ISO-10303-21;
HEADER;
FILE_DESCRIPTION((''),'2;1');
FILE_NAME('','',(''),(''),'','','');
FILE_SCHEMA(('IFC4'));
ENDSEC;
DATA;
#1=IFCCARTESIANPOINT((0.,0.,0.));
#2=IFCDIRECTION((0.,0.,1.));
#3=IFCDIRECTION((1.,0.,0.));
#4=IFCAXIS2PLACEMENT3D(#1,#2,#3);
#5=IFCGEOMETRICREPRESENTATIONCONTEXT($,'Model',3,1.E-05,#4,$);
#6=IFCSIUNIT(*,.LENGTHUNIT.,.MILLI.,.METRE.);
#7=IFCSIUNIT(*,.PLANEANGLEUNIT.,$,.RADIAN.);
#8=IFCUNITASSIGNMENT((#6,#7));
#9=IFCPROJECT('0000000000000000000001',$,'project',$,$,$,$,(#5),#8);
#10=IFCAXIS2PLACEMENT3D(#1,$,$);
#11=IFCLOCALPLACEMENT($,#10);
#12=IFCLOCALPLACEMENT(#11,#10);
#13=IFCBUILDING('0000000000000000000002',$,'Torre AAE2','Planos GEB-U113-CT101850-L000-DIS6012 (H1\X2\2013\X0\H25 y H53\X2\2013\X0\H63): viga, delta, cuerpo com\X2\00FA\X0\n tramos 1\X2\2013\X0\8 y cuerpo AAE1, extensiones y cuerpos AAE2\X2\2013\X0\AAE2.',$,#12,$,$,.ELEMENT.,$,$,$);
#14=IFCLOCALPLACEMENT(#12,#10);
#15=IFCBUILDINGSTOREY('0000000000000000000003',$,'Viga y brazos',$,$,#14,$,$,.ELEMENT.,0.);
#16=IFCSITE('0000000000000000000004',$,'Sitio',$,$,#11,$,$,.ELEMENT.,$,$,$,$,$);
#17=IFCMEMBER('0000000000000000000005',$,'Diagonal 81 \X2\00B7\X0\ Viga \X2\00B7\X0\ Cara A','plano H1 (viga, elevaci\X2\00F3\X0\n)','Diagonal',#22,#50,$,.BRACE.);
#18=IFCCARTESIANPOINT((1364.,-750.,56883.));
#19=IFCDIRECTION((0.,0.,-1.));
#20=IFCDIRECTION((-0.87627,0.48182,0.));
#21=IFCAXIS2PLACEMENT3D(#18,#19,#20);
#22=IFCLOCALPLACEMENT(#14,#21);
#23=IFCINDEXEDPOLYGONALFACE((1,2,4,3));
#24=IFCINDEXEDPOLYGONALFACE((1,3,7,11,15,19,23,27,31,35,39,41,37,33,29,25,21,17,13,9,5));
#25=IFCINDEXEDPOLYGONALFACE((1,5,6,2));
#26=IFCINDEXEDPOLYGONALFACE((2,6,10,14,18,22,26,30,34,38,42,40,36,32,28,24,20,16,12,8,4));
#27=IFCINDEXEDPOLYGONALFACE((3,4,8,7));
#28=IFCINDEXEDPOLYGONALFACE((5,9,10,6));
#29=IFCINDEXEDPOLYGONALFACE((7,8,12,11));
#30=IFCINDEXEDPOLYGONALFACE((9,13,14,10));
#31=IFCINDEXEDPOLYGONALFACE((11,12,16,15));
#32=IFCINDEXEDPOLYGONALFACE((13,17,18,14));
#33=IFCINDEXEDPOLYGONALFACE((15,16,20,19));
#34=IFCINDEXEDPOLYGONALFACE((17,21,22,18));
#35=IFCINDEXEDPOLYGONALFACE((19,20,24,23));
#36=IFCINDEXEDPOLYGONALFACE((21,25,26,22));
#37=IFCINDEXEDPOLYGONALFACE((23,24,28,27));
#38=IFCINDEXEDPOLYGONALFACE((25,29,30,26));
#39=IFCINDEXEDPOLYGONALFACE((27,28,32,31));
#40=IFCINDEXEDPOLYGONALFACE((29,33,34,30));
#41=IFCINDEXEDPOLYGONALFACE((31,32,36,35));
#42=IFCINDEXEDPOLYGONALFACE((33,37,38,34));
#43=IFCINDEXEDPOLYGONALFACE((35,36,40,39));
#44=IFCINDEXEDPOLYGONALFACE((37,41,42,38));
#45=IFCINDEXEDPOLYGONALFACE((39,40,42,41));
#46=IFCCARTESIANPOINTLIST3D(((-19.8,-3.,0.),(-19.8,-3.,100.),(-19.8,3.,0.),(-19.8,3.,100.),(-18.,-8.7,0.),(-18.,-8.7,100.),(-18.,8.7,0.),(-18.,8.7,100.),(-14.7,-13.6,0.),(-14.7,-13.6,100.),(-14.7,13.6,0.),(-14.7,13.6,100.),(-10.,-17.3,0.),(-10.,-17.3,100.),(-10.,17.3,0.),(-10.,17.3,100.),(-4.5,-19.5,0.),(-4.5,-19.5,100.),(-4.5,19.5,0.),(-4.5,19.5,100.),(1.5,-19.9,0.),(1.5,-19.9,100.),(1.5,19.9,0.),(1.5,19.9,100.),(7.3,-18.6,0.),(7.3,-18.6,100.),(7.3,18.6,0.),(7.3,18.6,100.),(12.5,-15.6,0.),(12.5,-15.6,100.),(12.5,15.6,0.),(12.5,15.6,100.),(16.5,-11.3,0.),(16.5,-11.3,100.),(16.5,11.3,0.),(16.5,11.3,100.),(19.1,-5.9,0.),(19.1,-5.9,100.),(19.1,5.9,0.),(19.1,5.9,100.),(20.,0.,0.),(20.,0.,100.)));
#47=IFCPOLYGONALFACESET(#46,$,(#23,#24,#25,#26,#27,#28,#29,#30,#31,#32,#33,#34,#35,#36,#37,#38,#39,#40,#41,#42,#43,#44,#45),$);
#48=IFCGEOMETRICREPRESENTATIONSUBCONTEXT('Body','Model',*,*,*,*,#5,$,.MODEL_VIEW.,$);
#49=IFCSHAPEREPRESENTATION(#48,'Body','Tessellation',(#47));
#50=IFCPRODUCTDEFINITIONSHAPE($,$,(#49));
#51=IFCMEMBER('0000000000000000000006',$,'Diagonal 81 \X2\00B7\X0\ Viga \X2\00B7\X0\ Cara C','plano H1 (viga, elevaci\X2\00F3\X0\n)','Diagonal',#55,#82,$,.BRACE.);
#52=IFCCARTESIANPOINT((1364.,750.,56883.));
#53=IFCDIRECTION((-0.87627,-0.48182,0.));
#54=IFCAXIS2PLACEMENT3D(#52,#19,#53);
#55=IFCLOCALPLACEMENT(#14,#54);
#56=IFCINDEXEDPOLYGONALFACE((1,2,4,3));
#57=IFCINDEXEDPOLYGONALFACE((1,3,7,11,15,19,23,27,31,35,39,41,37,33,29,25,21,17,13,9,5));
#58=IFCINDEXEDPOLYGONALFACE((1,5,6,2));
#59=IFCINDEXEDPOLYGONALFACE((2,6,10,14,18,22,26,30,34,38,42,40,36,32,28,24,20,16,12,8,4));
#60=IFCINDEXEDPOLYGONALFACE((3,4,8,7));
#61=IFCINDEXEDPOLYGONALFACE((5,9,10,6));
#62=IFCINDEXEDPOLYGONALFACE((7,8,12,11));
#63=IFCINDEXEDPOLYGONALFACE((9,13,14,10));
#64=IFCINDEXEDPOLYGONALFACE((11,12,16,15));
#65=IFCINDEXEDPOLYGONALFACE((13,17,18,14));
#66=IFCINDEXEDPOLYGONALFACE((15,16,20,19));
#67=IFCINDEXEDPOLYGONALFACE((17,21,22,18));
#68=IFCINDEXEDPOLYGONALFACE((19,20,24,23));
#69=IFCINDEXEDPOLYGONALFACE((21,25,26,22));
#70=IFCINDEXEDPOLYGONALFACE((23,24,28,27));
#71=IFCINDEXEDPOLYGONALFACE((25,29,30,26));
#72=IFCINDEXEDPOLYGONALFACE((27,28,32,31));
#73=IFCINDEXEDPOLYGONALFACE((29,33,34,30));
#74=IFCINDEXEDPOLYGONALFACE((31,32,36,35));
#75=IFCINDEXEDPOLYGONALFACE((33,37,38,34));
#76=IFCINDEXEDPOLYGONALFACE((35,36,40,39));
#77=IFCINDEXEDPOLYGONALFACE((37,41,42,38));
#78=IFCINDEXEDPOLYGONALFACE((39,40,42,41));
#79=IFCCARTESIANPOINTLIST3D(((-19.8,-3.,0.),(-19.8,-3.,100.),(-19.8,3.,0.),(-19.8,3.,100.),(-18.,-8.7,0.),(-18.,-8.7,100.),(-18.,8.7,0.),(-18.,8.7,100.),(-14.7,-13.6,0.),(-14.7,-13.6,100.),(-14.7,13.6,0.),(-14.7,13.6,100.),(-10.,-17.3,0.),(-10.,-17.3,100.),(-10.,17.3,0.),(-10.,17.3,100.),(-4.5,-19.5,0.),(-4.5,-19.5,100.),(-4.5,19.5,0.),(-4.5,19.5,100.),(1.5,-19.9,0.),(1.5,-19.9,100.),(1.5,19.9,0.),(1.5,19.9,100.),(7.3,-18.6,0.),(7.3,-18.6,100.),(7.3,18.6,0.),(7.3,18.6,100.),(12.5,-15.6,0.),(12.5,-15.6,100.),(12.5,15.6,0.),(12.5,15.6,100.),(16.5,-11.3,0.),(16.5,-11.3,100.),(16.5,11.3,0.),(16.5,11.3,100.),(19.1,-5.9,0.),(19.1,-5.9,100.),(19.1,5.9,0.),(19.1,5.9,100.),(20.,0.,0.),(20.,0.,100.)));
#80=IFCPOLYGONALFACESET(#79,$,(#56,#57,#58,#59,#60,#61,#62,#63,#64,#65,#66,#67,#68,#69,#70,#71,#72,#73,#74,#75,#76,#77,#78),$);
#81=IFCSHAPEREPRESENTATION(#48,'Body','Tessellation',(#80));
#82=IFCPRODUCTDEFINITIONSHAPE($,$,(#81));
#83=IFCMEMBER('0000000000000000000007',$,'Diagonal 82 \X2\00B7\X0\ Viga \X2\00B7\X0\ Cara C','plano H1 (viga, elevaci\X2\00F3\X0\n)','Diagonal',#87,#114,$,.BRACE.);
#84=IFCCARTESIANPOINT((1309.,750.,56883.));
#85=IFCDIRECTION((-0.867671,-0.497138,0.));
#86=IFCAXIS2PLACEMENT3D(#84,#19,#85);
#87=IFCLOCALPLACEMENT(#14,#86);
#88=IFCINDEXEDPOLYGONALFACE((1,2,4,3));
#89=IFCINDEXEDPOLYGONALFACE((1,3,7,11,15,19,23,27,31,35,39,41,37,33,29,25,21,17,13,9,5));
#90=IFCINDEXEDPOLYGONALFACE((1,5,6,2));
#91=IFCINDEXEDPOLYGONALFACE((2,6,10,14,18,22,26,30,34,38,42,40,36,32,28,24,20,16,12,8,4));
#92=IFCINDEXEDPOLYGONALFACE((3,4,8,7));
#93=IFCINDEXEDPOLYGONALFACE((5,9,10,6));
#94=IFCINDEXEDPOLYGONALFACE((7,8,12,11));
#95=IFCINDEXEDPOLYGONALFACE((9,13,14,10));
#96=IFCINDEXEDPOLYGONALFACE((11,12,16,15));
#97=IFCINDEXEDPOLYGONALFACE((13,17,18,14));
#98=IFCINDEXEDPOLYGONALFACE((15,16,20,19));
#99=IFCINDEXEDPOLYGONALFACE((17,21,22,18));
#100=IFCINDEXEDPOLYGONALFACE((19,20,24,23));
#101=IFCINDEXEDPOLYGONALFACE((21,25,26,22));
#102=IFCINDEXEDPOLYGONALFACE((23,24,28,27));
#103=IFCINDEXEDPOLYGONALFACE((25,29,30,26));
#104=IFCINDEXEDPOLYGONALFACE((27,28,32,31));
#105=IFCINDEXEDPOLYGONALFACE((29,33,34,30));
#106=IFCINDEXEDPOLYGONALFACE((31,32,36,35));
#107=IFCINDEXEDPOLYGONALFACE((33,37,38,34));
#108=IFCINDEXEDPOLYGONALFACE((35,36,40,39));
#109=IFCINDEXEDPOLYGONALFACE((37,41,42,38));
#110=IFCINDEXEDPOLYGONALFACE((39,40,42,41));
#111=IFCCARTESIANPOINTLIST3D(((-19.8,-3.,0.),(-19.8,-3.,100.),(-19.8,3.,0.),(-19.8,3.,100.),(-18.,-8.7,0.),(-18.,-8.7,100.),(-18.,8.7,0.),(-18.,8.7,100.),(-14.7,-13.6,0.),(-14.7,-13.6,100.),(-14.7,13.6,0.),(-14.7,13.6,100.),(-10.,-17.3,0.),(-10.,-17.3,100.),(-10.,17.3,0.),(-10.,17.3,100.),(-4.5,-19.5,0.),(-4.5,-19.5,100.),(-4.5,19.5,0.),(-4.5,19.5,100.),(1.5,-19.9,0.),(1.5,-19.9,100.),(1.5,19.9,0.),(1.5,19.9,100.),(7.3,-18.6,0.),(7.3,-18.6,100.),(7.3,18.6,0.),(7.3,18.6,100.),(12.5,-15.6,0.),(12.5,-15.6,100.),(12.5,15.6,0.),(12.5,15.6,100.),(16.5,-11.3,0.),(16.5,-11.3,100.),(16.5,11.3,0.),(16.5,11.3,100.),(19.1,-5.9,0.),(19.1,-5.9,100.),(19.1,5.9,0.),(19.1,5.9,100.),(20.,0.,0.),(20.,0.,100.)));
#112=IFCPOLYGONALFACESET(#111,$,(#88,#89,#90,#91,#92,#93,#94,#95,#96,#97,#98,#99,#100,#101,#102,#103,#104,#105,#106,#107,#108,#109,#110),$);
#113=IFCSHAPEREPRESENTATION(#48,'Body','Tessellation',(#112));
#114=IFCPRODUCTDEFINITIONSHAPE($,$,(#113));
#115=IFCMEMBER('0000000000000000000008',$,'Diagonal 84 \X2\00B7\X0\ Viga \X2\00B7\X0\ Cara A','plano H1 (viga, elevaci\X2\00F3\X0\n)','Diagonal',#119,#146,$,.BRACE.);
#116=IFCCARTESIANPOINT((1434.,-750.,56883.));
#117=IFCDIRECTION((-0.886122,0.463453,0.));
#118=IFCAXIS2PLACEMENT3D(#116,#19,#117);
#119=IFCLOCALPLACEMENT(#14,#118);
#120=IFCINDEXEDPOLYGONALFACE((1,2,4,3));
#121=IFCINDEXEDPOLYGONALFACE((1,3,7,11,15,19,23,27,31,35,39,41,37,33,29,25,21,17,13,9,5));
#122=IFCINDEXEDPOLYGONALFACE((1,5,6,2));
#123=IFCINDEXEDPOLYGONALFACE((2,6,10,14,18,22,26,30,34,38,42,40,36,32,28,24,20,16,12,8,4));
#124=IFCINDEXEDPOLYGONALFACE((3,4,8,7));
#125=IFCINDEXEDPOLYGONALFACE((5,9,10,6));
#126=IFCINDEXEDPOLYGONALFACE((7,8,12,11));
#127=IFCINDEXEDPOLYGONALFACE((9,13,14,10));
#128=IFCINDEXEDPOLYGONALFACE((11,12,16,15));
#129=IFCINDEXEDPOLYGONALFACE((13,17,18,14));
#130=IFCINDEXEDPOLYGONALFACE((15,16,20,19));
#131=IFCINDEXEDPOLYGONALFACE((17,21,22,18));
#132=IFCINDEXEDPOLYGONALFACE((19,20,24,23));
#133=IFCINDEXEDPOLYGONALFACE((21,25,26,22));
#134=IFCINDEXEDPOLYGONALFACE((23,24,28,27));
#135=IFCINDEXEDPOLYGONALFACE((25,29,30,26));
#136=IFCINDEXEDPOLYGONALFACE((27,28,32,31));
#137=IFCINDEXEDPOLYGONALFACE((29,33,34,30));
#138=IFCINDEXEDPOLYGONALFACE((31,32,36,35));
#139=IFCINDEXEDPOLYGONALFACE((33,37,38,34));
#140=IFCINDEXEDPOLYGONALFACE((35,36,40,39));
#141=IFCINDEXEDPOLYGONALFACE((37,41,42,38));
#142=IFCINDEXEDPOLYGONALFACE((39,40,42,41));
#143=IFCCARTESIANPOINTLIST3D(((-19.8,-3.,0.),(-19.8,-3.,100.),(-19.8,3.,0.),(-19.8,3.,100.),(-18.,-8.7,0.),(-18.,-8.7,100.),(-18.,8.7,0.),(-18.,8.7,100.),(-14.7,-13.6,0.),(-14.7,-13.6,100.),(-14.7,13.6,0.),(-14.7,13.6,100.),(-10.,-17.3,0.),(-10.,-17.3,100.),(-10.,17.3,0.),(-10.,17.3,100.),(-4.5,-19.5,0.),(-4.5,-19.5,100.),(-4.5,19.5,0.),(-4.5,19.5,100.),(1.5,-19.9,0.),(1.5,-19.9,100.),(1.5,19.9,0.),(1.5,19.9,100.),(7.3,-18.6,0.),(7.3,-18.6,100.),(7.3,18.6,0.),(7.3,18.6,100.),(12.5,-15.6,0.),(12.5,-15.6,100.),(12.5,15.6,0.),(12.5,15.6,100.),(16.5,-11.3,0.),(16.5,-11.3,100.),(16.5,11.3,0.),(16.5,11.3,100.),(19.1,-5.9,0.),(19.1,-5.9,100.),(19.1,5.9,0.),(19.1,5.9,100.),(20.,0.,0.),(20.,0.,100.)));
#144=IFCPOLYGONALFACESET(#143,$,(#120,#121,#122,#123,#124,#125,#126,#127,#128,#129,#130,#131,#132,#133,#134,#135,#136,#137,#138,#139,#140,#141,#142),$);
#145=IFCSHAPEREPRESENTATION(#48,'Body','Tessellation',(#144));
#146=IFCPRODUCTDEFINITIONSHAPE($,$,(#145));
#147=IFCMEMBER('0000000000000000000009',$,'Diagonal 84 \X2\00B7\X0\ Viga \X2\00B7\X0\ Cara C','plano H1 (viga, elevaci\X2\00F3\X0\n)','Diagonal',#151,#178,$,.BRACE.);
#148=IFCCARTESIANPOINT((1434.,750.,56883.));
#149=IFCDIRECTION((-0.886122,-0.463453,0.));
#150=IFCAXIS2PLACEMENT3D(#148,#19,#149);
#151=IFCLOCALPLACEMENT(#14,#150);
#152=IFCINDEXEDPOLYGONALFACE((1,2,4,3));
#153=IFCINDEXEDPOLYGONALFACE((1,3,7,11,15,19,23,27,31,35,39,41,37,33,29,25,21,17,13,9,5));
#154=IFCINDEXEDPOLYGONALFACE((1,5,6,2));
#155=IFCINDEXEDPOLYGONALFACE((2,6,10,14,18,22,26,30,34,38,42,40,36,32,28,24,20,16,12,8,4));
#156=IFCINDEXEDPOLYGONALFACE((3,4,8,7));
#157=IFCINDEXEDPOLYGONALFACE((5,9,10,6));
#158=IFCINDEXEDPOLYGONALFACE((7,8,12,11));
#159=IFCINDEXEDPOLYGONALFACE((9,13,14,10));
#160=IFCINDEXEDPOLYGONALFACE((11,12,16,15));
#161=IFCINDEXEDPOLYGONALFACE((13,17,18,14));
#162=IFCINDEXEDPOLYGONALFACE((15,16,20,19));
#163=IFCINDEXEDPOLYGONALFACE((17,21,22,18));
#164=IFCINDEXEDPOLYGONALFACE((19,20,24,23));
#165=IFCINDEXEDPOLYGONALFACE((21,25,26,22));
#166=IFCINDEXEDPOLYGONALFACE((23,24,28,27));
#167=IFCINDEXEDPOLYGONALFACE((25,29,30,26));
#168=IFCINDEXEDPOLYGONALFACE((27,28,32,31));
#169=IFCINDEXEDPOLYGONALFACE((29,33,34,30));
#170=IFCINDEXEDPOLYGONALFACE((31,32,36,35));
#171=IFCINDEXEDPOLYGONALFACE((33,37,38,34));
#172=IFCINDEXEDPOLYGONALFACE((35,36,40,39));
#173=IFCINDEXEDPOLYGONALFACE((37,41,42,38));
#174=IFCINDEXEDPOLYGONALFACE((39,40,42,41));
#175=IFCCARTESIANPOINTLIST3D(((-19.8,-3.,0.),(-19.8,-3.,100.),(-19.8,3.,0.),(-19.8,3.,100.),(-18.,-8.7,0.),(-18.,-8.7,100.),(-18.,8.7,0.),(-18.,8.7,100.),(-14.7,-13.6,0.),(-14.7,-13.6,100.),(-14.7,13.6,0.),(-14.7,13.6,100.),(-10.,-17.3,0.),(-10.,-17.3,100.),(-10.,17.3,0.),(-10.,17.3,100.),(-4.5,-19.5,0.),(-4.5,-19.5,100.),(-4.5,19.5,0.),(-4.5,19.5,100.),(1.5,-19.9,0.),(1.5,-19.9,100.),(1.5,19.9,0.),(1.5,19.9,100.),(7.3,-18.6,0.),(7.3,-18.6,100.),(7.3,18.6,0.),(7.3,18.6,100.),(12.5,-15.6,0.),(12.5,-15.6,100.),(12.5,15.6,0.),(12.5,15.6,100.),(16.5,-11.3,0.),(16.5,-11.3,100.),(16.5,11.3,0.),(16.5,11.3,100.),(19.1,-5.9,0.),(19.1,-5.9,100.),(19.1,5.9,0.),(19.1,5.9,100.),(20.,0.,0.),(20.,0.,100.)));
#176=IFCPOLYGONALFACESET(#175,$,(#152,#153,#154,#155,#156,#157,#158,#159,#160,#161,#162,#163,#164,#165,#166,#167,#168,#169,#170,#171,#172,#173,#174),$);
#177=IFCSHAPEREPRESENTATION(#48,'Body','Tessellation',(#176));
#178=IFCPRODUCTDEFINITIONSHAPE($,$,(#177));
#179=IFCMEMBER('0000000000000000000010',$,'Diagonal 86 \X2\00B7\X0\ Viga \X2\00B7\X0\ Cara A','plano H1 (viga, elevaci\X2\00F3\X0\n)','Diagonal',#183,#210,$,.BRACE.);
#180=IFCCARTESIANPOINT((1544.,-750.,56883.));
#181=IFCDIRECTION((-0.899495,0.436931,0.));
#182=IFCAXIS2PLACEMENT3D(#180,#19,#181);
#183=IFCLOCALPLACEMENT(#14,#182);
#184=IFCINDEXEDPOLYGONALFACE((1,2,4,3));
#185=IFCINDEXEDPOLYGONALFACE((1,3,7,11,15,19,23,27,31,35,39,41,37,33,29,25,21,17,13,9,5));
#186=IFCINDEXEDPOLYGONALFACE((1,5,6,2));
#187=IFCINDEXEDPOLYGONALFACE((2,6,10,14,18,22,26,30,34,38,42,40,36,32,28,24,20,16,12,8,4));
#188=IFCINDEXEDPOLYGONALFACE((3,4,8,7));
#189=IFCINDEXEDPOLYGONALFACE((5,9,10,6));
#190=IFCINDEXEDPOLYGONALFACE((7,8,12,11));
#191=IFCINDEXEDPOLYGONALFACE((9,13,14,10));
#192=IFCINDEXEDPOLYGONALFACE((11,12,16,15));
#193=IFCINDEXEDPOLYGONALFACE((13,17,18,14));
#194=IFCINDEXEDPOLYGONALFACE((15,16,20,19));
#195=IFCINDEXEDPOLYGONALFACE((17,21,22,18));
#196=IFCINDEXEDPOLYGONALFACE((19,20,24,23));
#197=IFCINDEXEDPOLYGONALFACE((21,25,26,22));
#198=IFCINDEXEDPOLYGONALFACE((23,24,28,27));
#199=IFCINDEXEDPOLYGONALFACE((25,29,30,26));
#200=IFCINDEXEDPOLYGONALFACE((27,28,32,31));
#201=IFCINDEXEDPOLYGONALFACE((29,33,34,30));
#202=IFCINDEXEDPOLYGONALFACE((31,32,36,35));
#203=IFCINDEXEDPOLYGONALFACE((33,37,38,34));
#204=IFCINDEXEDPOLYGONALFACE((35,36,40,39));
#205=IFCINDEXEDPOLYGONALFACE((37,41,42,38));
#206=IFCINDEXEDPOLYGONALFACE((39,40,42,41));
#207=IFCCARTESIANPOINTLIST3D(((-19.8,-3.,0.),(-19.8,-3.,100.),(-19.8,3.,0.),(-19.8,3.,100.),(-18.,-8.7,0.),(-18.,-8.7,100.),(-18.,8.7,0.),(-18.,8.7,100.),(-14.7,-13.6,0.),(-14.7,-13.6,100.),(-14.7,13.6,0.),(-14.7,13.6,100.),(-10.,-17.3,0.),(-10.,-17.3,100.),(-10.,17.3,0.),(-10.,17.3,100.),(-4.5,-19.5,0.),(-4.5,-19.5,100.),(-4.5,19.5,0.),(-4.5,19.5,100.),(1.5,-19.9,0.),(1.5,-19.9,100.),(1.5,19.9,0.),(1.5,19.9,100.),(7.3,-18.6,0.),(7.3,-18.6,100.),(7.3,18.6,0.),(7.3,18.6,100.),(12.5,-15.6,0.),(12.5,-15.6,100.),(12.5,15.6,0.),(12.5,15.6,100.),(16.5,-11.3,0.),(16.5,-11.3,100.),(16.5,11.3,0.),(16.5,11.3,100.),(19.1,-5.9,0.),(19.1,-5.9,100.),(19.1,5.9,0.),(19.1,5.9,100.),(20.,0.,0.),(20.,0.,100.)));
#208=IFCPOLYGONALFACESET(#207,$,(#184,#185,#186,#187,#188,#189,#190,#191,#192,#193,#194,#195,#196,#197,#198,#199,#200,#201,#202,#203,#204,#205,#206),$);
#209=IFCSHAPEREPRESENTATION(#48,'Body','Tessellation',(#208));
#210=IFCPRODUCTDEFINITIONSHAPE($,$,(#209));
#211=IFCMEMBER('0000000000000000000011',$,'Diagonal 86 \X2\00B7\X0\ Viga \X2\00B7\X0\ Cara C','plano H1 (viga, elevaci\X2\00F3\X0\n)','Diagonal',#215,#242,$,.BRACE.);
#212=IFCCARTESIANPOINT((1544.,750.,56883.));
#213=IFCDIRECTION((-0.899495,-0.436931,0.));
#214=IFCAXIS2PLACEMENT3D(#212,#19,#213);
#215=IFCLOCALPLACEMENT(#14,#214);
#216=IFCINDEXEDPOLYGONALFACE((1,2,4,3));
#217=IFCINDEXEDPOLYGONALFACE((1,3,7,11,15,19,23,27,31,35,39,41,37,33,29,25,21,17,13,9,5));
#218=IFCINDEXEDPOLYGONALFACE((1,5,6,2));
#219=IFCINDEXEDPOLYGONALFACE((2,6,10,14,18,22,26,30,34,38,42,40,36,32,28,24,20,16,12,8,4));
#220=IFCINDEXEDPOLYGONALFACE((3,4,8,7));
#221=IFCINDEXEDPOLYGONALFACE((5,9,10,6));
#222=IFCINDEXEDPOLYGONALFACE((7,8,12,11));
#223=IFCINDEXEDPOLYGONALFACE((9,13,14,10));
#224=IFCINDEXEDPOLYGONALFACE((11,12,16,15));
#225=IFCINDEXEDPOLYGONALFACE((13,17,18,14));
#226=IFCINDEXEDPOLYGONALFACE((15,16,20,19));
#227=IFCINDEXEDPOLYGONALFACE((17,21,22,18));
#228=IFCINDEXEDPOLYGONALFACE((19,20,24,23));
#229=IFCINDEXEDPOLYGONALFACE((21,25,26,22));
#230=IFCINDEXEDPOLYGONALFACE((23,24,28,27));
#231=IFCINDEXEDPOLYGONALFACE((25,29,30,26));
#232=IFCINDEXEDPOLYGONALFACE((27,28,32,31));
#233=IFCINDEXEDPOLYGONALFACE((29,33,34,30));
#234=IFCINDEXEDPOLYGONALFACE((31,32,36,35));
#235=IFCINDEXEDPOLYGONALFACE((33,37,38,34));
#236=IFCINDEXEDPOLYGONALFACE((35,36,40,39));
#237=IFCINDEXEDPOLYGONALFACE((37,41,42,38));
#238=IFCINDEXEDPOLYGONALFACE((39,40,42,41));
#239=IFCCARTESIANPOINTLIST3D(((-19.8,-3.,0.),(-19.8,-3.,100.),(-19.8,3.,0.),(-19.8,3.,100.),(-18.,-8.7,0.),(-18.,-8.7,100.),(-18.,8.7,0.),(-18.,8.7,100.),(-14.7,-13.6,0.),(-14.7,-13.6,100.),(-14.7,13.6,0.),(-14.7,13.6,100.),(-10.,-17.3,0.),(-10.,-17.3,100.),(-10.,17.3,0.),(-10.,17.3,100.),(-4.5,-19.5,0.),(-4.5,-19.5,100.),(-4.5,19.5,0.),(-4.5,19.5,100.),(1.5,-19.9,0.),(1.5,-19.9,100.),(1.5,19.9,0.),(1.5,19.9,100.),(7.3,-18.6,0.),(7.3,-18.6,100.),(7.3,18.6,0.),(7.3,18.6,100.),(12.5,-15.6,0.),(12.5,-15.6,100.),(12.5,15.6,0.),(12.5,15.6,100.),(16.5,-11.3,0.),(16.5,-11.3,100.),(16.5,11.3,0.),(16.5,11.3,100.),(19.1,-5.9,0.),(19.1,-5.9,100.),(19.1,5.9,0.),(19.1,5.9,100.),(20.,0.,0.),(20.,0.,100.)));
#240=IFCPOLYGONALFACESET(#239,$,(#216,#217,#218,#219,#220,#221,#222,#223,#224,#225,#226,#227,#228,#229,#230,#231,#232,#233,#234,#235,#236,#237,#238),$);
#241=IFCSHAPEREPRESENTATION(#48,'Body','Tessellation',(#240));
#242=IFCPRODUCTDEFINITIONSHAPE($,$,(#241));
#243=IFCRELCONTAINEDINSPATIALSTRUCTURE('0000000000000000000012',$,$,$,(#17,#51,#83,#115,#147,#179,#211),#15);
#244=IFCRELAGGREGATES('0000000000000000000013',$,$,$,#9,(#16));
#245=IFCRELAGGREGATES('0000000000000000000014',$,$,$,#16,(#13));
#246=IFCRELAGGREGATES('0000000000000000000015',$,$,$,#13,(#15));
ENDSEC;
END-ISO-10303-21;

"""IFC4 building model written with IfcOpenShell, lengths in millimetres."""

from ifc_helpers import new_model, si_unit, frame, origin, origin_with_axes, place, context, subcontext, project, spatial, circle, extrude, element, save


model = new_model("IFC4")

# Units and contexts
model_context = context("Model", 3, precision=1e-05, world=origin_with_axes())
body_context = subcontext(model_context, "Body", "Model", "MODEL_VIEW")
ifc_project = project(units=[si_unit("LENGTHUNIT", "METRE", prefix="MILLI"), si_unit("PLANEANGLEUNIT", "RADIAN")], contexts=[model_context])

# Site, building, storey
site_placement = place(None, origin())
site = spatial("IfcSite", under=ifc_project, at=site_placement, Name="Sitio", CompositionType="ELEMENT")
building_placement = place(site_placement, origin())
building = spatial("IfcBuilding", under=site, at=building_placement, Name="Torre AAE2", Description="Planos GEB-U113-CT101850-L000-DIS6012 (H1–H25 y H53–H63): viga, delta, cuerpo común tramos 1–8 y cuerpo AAE1, extensiones y cuerpos AAE2–AAE2.", CompositionType="ELEMENT")
storey_placement = place(building_placement, origin())
storey = spatial("IfcBuildingStorey", under=building, at=storey_placement, Name="Viga y brazos", CompositionType="ELEMENT", Elevation=0.0)

# Members
for number, where, z_axis, x_axis, name in (
    (1, (1364.0, -750.0, 56883.0), (0.0, 0.0, -1.0), (-0.87627, 0.48182, 0.0), "Diagonal 81 · Viga · Cara A"),
    (2, (1364.0, 750.0, 56883.0), (0.0, 0.0, -1.0), (-0.87627, -0.48182, 0.0), "Diagonal 81 · Viga · Cara C"),
    (3, (1309.0, 750.0, 56883.0), (0.0, 0.0, -1.0), (-0.867671, -0.497138, 0.0), "Diagonal 82 · Viga · Cara C"),
    (4, (1434.0, -750.0, 56883.0), (0.0, 0.0, -1.0), (-0.886122, 0.463453, 0.0), "Diagonal 84 · Viga · Cara A"),
    (5, (1434.0, 750.0, 56883.0), (0.0, 0.0, -1.0), (-0.886122, -0.463453, 0.0), "Diagonal 84 · Viga · Cara C"),
    (6, (1544.0, -750.0, 56883.0), (0.0, 0.0, -1.0), (-0.899495, 0.436931, 0.0), "Diagonal 86 · Viga · Cara A"),
    (7, (1544.0, 750.0, 56883.0), (0.0, 0.0, -1.0), (-0.899495, -0.436931, 0.0), "Diagonal 86 · Viga · Cara C"),
):
    element("IfcMember", number, at=place(storey_placement, frame(where, z_axis=z_axis, x_axis=x_axis)), inside=storey, Name=name, Description="plano H1 (viga, elevación)", ObjectType="Diagonal", PredefinedType="BRACE", context=body_context, shape_type="SweptSolid", body=[
        extrude(circle(Radius=20.0), None, (0.0, 0.0, 1.0), 100.0),
    ])

save(model, "model.ifc")
